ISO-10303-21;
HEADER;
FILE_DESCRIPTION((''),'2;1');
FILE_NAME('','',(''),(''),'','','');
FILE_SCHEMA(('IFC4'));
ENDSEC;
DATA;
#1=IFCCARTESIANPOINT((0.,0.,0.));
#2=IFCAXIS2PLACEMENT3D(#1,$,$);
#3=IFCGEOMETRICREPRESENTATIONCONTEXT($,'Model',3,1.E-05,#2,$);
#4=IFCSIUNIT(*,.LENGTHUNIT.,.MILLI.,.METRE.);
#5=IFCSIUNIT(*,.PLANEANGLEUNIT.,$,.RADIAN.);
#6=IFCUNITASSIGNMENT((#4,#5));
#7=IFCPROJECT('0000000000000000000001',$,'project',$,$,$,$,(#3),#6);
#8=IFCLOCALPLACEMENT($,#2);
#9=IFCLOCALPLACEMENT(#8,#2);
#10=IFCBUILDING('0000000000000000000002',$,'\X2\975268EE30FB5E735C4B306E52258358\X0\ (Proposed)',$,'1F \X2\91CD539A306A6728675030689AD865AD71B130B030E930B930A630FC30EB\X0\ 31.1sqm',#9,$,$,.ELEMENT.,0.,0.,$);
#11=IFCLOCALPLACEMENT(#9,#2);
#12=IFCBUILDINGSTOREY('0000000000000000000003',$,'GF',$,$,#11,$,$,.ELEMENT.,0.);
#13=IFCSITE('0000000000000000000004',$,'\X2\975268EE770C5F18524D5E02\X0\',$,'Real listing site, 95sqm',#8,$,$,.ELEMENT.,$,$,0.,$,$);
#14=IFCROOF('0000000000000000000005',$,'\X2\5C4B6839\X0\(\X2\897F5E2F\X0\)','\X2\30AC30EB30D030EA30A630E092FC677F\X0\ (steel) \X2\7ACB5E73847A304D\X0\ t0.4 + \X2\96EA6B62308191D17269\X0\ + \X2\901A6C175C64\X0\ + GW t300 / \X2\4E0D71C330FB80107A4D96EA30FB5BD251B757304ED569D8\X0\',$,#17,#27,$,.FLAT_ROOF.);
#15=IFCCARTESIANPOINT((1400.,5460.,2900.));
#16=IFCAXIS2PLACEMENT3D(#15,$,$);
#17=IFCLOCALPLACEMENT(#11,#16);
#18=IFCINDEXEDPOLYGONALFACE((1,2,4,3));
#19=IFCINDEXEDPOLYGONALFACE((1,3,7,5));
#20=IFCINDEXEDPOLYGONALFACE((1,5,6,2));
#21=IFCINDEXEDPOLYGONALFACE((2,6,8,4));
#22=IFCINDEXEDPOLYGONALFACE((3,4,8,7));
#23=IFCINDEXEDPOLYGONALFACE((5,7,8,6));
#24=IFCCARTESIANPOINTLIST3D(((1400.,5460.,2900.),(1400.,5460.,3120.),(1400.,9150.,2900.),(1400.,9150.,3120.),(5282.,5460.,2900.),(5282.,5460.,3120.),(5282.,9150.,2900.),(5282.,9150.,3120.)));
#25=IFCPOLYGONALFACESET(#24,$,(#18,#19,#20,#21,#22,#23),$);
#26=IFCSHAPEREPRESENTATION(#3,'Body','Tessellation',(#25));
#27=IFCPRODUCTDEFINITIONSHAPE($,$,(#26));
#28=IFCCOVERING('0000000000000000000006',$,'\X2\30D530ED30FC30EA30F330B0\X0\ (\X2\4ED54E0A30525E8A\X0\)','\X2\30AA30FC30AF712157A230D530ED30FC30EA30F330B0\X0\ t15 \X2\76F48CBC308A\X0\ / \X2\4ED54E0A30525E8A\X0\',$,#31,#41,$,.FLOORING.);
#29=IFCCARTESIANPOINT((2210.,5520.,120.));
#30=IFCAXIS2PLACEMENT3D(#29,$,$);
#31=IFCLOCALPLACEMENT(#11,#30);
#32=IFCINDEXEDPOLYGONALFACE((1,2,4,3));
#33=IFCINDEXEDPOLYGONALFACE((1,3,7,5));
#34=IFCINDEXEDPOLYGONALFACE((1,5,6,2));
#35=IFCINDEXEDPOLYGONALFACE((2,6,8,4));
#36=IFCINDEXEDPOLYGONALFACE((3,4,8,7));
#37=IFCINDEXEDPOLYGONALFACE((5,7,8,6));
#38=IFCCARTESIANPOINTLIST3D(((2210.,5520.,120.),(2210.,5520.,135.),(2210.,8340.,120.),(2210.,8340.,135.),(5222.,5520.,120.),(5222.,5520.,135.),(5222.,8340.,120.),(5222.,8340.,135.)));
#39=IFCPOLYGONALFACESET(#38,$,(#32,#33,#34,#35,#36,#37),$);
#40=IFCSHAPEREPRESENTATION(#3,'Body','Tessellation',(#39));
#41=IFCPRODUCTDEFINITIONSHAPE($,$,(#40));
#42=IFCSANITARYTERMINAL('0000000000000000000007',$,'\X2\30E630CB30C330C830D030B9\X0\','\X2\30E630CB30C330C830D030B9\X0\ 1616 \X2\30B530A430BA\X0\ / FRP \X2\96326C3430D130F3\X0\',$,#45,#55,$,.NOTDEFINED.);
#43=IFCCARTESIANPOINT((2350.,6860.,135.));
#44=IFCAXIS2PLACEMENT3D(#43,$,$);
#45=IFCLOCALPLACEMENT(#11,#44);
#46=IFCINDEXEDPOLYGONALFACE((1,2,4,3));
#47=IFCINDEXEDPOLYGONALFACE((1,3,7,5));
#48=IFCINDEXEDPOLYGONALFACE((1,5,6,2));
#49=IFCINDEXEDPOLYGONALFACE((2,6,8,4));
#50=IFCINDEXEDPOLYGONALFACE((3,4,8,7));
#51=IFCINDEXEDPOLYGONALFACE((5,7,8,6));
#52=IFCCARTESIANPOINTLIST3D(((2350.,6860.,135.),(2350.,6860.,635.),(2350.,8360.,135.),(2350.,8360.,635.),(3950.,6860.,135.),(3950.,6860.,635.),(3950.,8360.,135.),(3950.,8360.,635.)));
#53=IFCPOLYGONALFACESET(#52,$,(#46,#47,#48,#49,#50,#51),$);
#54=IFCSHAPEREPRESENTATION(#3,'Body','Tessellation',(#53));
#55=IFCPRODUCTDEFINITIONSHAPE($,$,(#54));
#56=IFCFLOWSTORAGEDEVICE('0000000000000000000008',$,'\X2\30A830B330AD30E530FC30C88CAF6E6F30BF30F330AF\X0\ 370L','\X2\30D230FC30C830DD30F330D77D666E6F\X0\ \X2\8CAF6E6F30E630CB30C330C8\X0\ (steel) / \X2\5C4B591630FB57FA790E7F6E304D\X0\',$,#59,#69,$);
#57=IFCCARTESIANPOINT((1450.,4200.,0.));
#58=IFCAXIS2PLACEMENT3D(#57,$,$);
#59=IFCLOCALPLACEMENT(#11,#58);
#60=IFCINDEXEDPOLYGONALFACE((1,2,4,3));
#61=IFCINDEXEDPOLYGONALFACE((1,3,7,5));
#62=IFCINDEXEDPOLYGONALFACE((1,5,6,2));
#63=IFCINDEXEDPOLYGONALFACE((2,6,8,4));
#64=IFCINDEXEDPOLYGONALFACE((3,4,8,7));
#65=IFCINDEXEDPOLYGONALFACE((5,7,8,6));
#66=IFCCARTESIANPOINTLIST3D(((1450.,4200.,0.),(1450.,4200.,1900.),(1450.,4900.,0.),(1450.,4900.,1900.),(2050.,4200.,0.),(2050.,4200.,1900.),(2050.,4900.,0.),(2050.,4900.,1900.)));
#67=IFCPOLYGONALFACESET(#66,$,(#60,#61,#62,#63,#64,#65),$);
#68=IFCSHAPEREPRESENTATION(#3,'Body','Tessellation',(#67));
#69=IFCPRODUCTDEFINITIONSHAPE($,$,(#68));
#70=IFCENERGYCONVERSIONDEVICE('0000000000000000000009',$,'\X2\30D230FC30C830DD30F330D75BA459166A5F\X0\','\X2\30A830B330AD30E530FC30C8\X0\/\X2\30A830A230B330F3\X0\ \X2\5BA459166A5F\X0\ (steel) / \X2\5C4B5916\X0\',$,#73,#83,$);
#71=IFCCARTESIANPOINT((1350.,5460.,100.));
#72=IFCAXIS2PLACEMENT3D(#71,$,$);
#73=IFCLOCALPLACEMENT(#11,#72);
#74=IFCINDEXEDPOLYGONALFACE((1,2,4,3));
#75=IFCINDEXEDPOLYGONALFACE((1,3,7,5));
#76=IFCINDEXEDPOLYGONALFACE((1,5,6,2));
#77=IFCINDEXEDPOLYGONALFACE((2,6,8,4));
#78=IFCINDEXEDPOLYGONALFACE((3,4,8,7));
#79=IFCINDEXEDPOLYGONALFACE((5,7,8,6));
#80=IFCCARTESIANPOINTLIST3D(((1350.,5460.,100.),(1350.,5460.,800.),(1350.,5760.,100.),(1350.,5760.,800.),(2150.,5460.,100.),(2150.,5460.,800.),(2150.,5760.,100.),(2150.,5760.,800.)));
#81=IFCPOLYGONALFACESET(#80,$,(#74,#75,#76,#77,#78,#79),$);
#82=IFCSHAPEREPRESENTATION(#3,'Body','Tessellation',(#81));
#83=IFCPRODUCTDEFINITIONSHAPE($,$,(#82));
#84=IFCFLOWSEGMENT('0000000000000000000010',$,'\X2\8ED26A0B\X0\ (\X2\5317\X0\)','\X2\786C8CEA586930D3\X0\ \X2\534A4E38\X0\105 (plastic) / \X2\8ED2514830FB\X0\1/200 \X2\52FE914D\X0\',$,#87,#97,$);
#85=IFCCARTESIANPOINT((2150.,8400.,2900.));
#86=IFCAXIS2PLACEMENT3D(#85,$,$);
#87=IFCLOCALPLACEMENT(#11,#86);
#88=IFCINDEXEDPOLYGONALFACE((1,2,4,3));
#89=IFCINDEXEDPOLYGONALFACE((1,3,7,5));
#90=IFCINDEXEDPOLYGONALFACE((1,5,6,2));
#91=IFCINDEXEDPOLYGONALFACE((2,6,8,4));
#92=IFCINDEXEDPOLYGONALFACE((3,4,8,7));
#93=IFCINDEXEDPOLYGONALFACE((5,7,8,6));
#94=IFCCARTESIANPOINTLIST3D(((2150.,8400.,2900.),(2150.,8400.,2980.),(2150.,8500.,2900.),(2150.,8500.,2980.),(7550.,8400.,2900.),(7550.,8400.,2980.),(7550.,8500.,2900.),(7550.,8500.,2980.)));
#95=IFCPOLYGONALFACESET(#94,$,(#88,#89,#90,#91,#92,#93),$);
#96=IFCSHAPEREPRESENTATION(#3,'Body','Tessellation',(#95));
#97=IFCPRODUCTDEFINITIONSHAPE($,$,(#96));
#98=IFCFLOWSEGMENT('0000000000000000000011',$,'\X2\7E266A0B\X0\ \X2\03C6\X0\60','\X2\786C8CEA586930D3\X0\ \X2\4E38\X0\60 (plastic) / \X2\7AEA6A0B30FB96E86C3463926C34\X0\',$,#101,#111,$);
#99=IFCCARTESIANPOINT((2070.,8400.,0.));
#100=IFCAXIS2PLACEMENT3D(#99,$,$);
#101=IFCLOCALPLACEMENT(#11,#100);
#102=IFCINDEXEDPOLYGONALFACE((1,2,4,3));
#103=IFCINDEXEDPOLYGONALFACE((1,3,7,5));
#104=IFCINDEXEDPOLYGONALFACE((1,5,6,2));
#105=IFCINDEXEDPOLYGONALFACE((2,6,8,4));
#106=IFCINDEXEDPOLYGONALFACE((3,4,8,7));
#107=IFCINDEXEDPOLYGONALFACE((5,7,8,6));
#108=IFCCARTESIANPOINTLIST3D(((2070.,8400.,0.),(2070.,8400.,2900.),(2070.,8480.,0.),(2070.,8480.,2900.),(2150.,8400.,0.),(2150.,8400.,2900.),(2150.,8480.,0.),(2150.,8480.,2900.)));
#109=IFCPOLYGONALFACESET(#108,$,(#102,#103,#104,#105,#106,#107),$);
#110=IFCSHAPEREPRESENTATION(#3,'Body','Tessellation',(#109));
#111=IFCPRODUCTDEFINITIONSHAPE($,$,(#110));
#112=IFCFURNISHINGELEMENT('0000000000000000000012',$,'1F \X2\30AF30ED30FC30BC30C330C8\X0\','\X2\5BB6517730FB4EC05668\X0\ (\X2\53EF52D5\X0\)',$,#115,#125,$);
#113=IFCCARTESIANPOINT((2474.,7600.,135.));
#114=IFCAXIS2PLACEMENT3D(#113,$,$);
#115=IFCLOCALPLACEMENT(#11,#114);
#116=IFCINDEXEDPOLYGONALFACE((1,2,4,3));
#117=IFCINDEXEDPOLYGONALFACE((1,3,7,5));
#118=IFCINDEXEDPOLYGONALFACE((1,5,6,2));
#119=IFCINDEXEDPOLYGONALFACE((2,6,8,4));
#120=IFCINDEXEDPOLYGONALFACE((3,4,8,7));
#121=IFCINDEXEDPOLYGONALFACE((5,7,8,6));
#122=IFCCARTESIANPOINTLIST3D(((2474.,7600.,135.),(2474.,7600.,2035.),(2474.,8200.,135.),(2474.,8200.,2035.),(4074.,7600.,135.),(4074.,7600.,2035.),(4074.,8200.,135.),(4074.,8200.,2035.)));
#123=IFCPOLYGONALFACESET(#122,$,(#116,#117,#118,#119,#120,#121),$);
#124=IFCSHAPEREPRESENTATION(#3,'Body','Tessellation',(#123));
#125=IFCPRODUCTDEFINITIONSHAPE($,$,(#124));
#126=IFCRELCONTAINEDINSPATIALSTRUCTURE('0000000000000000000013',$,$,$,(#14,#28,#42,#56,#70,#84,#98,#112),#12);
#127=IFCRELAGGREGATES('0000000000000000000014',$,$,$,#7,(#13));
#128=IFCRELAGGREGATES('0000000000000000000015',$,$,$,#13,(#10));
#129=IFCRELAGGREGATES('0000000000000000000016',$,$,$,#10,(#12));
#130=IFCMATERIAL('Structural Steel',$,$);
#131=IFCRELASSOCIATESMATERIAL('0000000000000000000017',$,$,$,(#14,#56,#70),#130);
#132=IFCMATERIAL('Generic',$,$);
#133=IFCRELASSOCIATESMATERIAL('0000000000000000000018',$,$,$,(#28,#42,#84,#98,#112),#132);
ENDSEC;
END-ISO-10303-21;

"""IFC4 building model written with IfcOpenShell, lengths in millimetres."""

from ifc_helpers import new_model, si_unit, frame, frame_2d, origin, place, context, project, spatial, rectangle, extrude, material, element, save


model = new_model("IFC4")

# Units and contexts
model_context = context("Model", 3, precision=1e-05, world=origin())
ifc_project = project(units=[si_unit("LENGTHUNIT", "METRE", prefix="MILLI"), si_unit("PLANEANGLEUNIT", "RADIAN")], contexts=[model_context])

# Site, building, storey
site_placement = place(None, origin())
site = spatial("IfcSite", under=ifc_project, at=site_placement, Name="青森県弘前市", ObjectType="Real listing site, 95sqm", CompositionType="ELEMENT", RefElevation=0.0)
building_placement = place(site_placement, origin())
building = spatial("IfcBuilding", under=site, at=building_placement, Name="青森・平屋の別荘 (Proposed)", ObjectType="1F 重厚な木材と高断熱グラスウール 31.1sqm", CompositionType="ELEMENT", ElevationOfRefHeight=0.0, ElevationOfTerrain=0.0)
storey_placement = place(building_placement, origin())
storey = spatial("IfcBuildingStorey", under=building, at=storey_placement, Name="GF", CompositionType="ELEMENT", Elevation=0.0)

# Roof
ifc_material_1 = material(Name="Structural Steel")
roof_placement = place(storey_placement, frame((1400.0, 5460.0, 2900.0)))
element("IfcRoof", 1, at=roof_placement, inside=storey, material=ifc_material_1, Name="屋根(西帯)", Description="ガルバリウム鋼板 (steel) 立平葺き t0.4 + 雪止め金物 + 通気層 + GW t300 / 不燃・耐積雪・寒冷地仕様", PredefinedType="FLAT_ROOF", context=model_context, shape_type="SweptSolid", body=[
    extrude(rectangle(XDim=3882.0, YDim=3690.0, at=frame_2d((1941.0, 1845.0))), frame((1400.0, 5460.0, 2900.0)), (0.0, 0.0, 1.0), 220.0),
])

# Covering
ifc_material_2 = material(Name="Generic")
covering_placement = place(storey_placement, frame((2210.0, 5520.0, 120.0)))
element("IfcCovering", 2, at=covering_placement, inside=storey, material=ifc_material_2, Name="フローリング (仕上げ床)", Description="オーク無垢フローリング t15 直貼り / 仕上げ床", PredefinedType="FLOORING", context=model_context, shape_type="SweptSolid", body=[
    extrude(rectangle(XDim=3012.0, YDim=2820.0, at=frame_2d((1506.0, 1410.0))), frame((2210.0, 5520.0, 120.0)), (0.0, 0.0, 1.0), 15.0),
])

# Sanitary terminal
sanitary_terminal_placement = place(storey_placement, frame((2350.0, 6860.0, 135.0)))
element("IfcSanitaryTerminal", 3, at=sanitary_terminal_placement, inside=storey, material=ifc_material_2, Name="ユニットバス", Description="ユニットバス 1616 サイズ / FRP 防水パン", PredefinedType="NOTDEFINED", context=model_context, shape_type="SweptSolid", body=[
    extrude(rectangle(XDim=1600.0, YDim=1500.0, at=frame_2d((800.0, 750.0))), frame((2350.0, 6860.0, 135.0)), (0.0, 0.0, 1.0), 500.0),
])

# Flow storage device
flow_storage_device_placement = place(storey_placement, frame((1450.0, 4200.0, 0.0)))
element("IfcFlowStorageDevice", 4, at=flow_storage_device_placement, inside=storey, material=ifc_material_1, Name="エコキュート貯湯タンク 370L", Description="ヒートポンプ給湯 貯湯ユニット (steel) / 屋外・基礎置き", context=model_context, shape_type="SweptSolid", body=[
    extrude(rectangle(XDim=600.0, YDim=700.0, at=frame_2d((300.0, 350.0))), frame((1450.0, 4200.0, 0.0)), (0.0, 0.0, 1.0), 1900.0),
])

# Energy conversion device
energy_conversion_device_placement = place(storey_placement, frame((1350.0, 5460.0, 100.0)))
element("IfcEnergyConversionDevice", 5, at=energy_conversion_device_placement, inside=storey, material=ifc_material_1, Name="ヒートポンプ室外機", Description="エコキュート/エアコン 室外機 (steel) / 屋外", context=model_context, shape_type="SweptSolid", body=[
    extrude(rectangle(XDim=800.0, YDim=300.0, at=frame_2d((400.0, 150.0))), frame((1350.0, 5460.0, 100.0)), (0.0, 0.0, 1.0), 700.0),
])

# Flow segments
flow_segment_1_placement = place(storey_placement, frame((2150.0, 8400.0, 2900.0)))
element("IfcFlowSegment", 6, at=flow_segment_1_placement, inside=storey, material=ifc_material_2, Name="軒樋 (北)", Description="硬質塩ビ 半丸105 (plastic) / 軒先・1/200 勾配", context=model_context, shape_type="SweptSolid", body=[
    extrude(rectangle(XDim=5400.0, YDim=100.0, at=frame_2d((2700.0, 50.0))), frame((2150.0, 8400.0, 2900.0)), (0.0, 0.0, 1.0), 80.0),
])
flow_segment_2_placement = place(storey_placement, frame((2070.0, 8400.0, 0.0)))
element("IfcFlowSegment", 7, at=flow_segment_2_placement, inside=storey, material=ifc_material_2, Name="縦樋 φ60", Description="硬質塩ビ 丸60 (plastic) / 竪樋・雨水排水", context=model_context, shape_type="SweptSolid", body=[
    extrude(rectangle(XDim=80.0, YDim=80.0, at=frame_2d((40.0, 40.0))), frame((2070.0, 8400.0, 0.0)), (0.0, 0.0, 1.0), 2900.0),
])

# Furnishing element
furnishing_placement = place(storey_placement, frame((2474.0, 7600.0, 135.0)))
element("IfcFurnishingElement", 8, at=furnishing_placement, inside=storey, material=ifc_material_2, Name="1F クローゼット", Description="家具・什器 (可動)", context=model_context, shape_type="SweptSolid", body=[
    extrude(rectangle(XDim=1600.0, YDim=600.0, at=frame_2d((800.0, 300.0))), frame((2474.0, 7600.0, 135.0)), (0.0, 0.0, 1.0), 1900.0),
])

save(model, "model.ifc")
